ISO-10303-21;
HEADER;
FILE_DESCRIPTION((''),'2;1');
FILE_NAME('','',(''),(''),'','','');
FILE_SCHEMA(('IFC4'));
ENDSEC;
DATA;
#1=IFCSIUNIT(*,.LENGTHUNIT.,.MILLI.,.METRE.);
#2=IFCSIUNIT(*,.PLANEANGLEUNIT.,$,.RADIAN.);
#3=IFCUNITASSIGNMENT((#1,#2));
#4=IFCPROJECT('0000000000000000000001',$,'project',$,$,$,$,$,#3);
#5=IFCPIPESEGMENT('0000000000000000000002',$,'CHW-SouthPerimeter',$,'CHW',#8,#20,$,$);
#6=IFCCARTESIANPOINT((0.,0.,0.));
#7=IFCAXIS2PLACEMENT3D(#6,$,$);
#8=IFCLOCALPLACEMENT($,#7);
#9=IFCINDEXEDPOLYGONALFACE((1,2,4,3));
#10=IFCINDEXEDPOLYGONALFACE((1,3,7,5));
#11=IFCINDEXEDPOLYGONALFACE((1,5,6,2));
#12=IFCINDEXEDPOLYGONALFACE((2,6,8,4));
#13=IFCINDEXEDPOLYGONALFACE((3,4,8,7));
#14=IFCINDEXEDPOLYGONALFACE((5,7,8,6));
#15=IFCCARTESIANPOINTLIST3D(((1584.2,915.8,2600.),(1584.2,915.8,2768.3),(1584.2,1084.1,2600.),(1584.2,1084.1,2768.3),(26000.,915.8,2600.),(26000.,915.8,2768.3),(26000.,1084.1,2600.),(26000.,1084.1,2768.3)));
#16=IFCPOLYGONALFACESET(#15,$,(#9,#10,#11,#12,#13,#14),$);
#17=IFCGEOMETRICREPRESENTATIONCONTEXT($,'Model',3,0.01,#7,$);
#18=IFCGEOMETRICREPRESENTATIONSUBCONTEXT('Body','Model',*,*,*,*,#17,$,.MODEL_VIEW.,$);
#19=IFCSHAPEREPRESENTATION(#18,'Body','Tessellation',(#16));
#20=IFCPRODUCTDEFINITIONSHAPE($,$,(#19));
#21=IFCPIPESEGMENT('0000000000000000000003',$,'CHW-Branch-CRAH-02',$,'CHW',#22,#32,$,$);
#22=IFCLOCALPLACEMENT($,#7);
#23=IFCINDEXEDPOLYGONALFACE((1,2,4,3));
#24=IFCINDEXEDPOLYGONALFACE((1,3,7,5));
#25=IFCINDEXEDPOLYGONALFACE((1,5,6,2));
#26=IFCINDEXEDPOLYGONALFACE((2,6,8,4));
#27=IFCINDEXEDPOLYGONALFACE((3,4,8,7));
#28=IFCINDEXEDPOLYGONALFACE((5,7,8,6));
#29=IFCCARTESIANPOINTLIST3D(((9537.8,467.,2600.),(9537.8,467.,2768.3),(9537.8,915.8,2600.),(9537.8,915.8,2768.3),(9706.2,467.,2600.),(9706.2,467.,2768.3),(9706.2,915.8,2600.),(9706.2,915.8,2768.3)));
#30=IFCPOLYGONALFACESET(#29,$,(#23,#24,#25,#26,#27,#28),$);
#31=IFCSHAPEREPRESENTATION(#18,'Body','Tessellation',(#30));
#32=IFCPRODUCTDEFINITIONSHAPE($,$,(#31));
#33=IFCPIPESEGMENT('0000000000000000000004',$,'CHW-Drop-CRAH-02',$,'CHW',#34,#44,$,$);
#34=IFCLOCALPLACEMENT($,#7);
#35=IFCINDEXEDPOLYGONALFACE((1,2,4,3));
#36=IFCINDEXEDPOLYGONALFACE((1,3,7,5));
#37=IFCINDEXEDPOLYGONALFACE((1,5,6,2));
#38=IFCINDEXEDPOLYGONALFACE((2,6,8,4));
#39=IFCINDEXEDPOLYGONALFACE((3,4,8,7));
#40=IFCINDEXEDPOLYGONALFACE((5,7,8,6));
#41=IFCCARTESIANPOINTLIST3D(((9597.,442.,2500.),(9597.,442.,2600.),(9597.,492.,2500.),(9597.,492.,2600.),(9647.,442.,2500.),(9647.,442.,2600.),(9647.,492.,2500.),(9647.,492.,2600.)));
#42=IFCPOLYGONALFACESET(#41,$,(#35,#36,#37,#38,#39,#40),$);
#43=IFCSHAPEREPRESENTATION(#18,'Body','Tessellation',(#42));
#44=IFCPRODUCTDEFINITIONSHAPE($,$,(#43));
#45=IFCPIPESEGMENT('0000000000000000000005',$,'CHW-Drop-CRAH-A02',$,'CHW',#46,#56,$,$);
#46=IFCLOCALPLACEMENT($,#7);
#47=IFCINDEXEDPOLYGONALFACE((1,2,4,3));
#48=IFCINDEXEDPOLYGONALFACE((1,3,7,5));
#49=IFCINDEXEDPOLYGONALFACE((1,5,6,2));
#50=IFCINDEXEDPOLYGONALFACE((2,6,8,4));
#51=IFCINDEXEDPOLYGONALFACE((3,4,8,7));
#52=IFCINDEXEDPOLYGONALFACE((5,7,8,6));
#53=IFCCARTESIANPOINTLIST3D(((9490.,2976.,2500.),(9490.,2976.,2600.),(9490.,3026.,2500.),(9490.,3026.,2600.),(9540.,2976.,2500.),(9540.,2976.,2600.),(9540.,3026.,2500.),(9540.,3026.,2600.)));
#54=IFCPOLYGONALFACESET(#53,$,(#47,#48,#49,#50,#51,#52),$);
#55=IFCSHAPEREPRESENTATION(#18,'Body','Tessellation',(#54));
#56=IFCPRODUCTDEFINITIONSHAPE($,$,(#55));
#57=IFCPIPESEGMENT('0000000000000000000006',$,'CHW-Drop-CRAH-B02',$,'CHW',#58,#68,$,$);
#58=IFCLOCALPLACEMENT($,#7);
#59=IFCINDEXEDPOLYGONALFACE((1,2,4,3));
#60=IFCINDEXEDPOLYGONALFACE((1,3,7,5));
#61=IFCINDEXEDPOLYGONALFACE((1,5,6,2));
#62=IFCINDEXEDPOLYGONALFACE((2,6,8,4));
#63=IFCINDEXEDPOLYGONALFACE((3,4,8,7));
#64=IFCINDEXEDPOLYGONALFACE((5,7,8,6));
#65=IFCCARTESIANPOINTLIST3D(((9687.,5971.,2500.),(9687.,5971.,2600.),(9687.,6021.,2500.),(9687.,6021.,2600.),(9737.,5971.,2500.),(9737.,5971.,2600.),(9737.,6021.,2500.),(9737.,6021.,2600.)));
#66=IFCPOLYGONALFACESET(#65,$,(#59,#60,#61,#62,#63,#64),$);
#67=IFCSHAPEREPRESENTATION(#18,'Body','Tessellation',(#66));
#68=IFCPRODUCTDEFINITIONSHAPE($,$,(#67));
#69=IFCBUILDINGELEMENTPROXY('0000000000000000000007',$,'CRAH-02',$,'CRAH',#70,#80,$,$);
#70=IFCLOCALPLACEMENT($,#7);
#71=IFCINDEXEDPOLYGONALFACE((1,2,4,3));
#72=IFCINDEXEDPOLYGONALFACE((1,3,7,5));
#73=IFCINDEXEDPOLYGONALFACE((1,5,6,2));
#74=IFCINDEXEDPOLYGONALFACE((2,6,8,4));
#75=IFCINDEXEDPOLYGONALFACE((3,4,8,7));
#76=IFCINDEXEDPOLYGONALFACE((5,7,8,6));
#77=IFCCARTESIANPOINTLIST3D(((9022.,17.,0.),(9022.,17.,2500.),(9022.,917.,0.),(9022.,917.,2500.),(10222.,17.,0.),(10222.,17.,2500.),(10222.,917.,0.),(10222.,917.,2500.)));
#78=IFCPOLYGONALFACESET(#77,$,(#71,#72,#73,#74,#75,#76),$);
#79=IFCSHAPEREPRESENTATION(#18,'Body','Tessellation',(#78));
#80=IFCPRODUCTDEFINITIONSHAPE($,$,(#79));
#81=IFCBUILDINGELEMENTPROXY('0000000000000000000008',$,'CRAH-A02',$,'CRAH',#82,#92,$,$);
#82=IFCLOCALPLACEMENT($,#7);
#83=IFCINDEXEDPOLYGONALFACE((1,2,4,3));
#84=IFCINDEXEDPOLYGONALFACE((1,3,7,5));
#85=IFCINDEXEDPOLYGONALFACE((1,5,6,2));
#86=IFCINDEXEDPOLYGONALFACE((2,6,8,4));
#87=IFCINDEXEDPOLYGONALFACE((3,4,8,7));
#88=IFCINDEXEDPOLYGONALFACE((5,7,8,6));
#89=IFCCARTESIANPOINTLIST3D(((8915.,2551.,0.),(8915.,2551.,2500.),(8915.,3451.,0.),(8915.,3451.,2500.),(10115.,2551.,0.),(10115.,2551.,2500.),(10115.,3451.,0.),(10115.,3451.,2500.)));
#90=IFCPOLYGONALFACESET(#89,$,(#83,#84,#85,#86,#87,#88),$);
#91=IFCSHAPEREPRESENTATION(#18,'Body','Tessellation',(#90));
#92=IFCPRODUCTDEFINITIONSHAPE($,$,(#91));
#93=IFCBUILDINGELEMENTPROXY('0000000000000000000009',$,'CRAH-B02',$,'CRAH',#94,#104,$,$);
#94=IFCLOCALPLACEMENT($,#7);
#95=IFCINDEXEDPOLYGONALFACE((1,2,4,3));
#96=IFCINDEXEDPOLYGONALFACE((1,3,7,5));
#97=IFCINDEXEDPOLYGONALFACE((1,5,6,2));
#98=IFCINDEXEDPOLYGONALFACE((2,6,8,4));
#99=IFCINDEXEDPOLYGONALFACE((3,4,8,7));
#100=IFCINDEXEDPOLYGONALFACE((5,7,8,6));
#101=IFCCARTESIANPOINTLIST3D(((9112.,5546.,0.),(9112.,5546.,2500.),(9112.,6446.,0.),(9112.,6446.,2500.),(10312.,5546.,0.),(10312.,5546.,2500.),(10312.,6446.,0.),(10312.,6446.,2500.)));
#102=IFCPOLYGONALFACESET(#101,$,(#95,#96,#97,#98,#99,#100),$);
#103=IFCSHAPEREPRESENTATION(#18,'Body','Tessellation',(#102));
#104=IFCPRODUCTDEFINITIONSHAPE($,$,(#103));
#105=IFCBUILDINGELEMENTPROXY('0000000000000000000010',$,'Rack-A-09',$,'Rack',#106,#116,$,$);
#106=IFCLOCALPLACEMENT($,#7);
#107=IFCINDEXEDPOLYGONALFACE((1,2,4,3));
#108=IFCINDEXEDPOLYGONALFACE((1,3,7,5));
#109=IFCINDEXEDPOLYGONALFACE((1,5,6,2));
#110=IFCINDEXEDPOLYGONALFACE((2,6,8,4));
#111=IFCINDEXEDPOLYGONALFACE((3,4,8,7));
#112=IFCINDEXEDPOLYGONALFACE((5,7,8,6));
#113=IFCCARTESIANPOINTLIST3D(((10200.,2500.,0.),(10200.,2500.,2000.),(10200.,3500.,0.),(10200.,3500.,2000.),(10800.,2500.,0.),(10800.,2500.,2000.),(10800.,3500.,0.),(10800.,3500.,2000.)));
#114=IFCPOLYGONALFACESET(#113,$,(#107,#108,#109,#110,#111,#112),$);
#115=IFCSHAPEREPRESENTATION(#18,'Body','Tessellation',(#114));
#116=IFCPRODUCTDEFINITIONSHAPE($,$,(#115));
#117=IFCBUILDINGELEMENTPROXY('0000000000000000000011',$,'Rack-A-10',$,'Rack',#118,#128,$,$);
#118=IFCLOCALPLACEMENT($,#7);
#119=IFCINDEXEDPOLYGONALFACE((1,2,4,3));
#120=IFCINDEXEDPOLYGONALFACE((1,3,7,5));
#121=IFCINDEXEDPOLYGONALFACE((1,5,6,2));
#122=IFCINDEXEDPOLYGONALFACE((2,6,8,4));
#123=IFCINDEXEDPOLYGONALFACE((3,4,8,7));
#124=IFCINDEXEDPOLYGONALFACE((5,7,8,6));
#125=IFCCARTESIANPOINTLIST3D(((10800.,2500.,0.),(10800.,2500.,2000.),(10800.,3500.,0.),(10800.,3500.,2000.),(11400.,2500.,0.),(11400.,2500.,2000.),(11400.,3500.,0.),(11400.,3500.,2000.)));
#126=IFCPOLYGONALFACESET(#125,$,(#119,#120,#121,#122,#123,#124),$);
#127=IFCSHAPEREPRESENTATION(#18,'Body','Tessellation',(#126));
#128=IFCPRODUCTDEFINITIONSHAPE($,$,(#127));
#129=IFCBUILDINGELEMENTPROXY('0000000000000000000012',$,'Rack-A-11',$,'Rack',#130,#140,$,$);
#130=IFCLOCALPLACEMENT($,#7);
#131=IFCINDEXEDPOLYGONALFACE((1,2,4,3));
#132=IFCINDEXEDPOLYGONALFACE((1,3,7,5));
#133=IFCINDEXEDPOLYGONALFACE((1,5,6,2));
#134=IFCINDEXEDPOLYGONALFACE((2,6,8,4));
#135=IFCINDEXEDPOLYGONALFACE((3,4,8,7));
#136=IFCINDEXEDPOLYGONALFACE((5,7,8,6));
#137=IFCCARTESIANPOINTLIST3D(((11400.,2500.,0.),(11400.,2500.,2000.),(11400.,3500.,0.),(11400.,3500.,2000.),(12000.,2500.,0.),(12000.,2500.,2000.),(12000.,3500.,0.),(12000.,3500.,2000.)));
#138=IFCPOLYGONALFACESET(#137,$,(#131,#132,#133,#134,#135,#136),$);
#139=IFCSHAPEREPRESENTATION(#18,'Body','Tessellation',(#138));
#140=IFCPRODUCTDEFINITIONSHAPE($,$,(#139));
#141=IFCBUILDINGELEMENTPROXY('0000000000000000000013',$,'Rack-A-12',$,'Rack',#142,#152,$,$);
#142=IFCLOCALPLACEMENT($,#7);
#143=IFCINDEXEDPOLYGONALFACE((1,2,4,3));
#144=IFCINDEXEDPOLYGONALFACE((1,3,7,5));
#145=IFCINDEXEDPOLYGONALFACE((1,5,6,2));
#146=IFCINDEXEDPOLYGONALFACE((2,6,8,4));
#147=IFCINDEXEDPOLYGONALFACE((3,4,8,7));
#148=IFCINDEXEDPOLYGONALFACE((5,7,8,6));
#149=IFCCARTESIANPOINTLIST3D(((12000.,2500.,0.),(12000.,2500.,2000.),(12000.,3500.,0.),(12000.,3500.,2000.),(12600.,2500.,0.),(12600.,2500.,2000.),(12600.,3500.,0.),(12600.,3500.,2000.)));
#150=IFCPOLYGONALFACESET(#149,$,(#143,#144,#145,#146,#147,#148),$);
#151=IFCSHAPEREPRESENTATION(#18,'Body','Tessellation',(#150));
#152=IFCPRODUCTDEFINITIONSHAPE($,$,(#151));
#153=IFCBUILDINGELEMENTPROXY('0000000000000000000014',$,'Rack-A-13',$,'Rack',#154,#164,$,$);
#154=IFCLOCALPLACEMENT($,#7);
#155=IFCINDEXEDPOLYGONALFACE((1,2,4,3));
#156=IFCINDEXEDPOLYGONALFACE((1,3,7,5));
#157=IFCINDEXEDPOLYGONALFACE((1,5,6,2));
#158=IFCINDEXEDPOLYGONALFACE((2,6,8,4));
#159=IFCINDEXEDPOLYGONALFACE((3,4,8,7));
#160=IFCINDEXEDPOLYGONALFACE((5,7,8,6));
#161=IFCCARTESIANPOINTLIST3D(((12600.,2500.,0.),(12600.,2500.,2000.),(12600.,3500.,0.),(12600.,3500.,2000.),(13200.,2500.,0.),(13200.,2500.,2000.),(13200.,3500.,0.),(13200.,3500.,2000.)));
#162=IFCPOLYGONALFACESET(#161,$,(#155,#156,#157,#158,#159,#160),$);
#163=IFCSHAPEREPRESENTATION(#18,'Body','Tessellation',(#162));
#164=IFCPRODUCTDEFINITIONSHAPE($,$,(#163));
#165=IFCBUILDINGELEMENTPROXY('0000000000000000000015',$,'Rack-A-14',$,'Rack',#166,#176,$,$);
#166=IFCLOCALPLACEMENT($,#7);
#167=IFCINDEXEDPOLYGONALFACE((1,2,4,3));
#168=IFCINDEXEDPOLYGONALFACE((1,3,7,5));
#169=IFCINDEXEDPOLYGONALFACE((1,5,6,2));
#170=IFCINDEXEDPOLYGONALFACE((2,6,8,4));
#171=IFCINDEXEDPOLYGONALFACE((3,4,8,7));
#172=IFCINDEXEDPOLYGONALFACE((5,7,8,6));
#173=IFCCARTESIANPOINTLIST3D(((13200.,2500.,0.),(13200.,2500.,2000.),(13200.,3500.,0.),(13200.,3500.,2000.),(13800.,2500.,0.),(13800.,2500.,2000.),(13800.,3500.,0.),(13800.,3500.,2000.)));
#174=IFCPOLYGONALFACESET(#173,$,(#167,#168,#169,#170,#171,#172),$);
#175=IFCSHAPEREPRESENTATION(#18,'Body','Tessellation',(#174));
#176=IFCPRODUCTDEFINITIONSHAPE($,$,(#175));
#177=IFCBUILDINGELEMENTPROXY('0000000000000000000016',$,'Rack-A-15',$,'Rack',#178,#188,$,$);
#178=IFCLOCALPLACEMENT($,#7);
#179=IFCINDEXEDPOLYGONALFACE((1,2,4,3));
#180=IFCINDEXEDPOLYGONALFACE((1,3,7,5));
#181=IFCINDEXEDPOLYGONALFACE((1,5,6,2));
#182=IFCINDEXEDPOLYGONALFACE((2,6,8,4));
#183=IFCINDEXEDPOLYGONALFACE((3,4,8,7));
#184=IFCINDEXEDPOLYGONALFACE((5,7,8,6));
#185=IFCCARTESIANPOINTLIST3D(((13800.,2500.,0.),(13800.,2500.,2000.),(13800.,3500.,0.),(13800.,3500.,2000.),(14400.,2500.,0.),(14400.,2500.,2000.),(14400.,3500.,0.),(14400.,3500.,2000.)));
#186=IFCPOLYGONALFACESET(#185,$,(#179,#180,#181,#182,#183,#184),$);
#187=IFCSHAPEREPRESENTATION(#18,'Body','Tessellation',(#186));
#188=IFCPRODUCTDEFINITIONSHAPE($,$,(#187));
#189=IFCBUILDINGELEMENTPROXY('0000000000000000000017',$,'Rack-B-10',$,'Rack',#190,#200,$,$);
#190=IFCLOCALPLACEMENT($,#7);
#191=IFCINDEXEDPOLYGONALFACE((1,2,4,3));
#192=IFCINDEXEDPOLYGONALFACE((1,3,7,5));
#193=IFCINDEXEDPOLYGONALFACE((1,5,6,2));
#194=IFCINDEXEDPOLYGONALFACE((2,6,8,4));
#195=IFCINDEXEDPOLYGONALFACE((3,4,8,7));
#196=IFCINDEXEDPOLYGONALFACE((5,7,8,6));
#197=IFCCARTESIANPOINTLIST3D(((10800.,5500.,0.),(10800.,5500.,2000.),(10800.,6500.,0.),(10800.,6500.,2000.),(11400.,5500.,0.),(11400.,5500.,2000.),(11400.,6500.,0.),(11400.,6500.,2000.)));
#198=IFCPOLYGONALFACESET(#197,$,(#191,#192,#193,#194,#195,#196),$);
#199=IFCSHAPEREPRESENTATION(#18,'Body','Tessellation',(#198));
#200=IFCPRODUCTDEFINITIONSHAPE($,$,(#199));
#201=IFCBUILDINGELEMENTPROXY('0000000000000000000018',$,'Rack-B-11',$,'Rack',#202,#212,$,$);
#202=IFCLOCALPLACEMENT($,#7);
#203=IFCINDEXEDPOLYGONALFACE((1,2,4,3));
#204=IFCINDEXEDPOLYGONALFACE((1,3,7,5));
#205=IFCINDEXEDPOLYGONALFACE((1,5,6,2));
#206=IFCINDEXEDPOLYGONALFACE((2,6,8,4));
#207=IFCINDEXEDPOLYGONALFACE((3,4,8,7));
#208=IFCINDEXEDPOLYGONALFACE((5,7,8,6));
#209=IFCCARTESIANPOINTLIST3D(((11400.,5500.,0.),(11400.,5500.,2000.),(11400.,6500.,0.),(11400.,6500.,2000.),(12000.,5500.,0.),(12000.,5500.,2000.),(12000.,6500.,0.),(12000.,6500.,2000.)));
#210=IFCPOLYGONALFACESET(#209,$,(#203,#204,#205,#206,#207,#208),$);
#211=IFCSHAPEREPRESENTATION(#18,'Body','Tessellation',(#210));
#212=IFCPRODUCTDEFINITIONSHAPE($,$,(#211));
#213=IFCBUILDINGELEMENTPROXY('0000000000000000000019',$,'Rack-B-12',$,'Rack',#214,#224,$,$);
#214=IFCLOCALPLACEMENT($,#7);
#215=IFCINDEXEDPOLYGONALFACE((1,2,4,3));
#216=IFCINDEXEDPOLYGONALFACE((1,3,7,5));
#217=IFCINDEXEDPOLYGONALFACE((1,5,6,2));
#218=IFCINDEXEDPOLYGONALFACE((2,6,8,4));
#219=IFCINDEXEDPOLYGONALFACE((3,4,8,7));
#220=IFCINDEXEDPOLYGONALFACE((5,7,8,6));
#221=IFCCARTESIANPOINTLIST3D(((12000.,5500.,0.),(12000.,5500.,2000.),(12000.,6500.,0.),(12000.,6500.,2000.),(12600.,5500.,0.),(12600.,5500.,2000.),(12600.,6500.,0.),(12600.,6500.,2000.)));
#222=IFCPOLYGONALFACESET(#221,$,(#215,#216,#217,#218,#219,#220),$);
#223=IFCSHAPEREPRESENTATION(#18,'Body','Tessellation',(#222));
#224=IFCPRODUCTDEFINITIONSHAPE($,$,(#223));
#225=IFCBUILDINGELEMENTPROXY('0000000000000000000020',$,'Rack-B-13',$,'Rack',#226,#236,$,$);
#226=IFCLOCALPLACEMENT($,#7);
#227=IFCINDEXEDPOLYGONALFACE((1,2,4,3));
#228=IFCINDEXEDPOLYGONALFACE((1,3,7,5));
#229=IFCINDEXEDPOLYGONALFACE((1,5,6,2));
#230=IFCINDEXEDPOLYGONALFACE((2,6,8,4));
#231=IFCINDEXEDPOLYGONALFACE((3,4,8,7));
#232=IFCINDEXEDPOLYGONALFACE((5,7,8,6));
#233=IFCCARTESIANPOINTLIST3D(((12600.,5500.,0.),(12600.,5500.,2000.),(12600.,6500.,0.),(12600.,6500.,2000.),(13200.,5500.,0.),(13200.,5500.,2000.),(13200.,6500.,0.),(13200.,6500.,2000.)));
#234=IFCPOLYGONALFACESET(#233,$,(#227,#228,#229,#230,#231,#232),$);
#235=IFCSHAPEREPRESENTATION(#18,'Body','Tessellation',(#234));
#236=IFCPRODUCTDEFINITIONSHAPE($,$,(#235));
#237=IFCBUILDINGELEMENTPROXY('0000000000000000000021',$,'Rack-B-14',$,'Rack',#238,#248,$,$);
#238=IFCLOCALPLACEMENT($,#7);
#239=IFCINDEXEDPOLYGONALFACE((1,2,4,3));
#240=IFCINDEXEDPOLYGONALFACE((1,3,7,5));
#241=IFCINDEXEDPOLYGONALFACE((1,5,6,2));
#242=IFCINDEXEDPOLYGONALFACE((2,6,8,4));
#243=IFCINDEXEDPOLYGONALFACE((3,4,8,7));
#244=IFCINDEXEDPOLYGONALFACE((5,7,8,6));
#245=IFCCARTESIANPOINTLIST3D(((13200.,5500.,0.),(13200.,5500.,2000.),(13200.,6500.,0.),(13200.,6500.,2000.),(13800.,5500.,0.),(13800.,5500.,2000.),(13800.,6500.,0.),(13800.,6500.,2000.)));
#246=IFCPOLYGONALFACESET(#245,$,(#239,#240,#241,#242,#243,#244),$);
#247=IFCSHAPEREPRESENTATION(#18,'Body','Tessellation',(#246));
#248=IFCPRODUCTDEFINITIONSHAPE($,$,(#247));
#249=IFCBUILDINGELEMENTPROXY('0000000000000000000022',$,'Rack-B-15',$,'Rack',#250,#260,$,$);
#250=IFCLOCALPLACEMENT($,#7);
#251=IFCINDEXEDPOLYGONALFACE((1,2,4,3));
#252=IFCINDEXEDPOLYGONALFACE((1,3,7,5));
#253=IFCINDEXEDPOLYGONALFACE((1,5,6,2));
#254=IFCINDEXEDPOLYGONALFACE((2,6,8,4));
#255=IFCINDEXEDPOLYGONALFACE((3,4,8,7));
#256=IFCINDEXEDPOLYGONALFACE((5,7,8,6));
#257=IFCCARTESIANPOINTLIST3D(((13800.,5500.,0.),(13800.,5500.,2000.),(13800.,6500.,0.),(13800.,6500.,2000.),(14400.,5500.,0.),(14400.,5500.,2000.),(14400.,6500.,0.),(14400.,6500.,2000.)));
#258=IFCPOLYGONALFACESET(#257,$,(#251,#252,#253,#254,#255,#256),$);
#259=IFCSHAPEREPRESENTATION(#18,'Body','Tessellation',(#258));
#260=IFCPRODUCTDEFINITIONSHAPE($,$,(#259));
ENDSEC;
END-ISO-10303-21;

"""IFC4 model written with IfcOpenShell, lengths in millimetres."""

from ifc_helpers import new_model, si_unit, frame, origin, place, context, subcontext, project, rectangle, extrude, element, save


model = new_model("IFC4")

# Units and contexts
model_context = context("Model", 3, precision=0.01, world=origin())
body_context = subcontext(model_context, "Body", "Model", "MODEL_VIEW")
ifc_project = project(units=[si_unit("LENGTHUNIT", "METRE", prefix="MILLI"), si_unit("PLANEANGLEUNIT", "RADIAN")])

# Pipe segments
placement = place(None, origin())
pipe_segment_1_placement = place(placement, frame((13792.1, 1000.0, 2600.0)))
element("IfcPipeSegment", 1, at=pipe_segment_1_placement, Name="CHW-SouthPerimeter", ObjectType="CHW", context=body_context, shape_type="SweptSolid", body=[
    extrude(rectangle(XDim=24415.8, YDim=168.3), origin(), (0.0, 0.0, 1.0), 168.3),
])
pipe_segment_2_placement = place(placement, frame((9622.0, 691.4, 2600.0)))
element("IfcPipeSegment", 2, at=pipe_segment_2_placement, Name="CHW-Branch-CRAH-02", ObjectType="CHW", context=body_context, shape_type="SweptSolid", body=[
    extrude(rectangle(XDim=168.3, YDim=448.9), origin(), (0.0, 0.0, 1.0), 168.3),
])
for number, where, name in (
    (3, (9622.0, 467.0, 2500.0), "CHW-Drop-CRAH-02"),
    (4, (9515.0, 3001.0, 2500.0), "CHW-Drop-CRAH-A02"),
    (5, (9712.0, 5996.0, 2500.0), "CHW-Drop-CRAH-B02"),
):
    element("IfcPipeSegment", number, at=place(placement, frame(where)), Name=name, ObjectType="CHW", context=body_context, shape_type="SweptSolid", body=[
        extrude(rectangle(XDim=50.0, YDim=50.0), origin(), (0.0, 0.0, 1.0), 100.0),
    ])

# Building element proxies
for number, where, name in (
    (6, (9622.0, 467.0, 0.0), "CRAH-02"),
    (7, (9515.0, 3001.0, 0.0), "CRAH-A02"),
    (8, (9712.0, 5996.0, 0.0), "CRAH-B02"),
):
    element("IfcBuildingElementProxy", number, at=place(placement, frame(where)), Name=name, ObjectType="CRAH", context=body_context, shape_type="SweptSolid", body=[
        extrude(rectangle(XDim=1200.0, YDim=900.0), origin(), (0.0, 0.0, 1.0), 2500.0),
    ])
for number, where, name in (
    (9, (10500.0, 3000.0, 0.0), "Rack-A-09"),
    (10, (11100.0, 3000.0, 0.0), "Rack-A-10"),
    (11, (11700.0, 3000.0, 0.0), "Rack-A-11"),
    (12, (12300.0, 3000.0, 0.0), "Rack-A-12"),
    (13, (12900.0, 3000.0, 0.0), "Rack-A-13"),
    (14, (13500.0, 3000.0, 0.0), "Rack-A-14"),
    (15, (14100.0, 3000.0, 0.0), "Rack-A-15"),
    (16, (11100.0, 6000.0, 0.0), "Rack-B-10"),
    (17, (11700.0, 6000.0, 0.0), "Rack-B-11"),
    (18, (12300.0, 6000.0, 0.0), "Rack-B-12"),
    (19, (12900.0, 6000.0, 0.0), "Rack-B-13"),
    (20, (13500.0, 6000.0, 0.0), "Rack-B-14"),
    (21, (14100.0, 6000.0, 0.0), "Rack-B-15"),
):
    element("IfcBuildingElementProxy", number, at=place(placement, frame(where)), Name=name, ObjectType="Rack", context=body_context, shape_type="SweptSolid", body=[
        extrude(rectangle(XDim=600.0, YDim=1000.0), origin(), (0.0, 0.0, 1.0), 2000.0),
    ])

save(model, "model.ifc")
